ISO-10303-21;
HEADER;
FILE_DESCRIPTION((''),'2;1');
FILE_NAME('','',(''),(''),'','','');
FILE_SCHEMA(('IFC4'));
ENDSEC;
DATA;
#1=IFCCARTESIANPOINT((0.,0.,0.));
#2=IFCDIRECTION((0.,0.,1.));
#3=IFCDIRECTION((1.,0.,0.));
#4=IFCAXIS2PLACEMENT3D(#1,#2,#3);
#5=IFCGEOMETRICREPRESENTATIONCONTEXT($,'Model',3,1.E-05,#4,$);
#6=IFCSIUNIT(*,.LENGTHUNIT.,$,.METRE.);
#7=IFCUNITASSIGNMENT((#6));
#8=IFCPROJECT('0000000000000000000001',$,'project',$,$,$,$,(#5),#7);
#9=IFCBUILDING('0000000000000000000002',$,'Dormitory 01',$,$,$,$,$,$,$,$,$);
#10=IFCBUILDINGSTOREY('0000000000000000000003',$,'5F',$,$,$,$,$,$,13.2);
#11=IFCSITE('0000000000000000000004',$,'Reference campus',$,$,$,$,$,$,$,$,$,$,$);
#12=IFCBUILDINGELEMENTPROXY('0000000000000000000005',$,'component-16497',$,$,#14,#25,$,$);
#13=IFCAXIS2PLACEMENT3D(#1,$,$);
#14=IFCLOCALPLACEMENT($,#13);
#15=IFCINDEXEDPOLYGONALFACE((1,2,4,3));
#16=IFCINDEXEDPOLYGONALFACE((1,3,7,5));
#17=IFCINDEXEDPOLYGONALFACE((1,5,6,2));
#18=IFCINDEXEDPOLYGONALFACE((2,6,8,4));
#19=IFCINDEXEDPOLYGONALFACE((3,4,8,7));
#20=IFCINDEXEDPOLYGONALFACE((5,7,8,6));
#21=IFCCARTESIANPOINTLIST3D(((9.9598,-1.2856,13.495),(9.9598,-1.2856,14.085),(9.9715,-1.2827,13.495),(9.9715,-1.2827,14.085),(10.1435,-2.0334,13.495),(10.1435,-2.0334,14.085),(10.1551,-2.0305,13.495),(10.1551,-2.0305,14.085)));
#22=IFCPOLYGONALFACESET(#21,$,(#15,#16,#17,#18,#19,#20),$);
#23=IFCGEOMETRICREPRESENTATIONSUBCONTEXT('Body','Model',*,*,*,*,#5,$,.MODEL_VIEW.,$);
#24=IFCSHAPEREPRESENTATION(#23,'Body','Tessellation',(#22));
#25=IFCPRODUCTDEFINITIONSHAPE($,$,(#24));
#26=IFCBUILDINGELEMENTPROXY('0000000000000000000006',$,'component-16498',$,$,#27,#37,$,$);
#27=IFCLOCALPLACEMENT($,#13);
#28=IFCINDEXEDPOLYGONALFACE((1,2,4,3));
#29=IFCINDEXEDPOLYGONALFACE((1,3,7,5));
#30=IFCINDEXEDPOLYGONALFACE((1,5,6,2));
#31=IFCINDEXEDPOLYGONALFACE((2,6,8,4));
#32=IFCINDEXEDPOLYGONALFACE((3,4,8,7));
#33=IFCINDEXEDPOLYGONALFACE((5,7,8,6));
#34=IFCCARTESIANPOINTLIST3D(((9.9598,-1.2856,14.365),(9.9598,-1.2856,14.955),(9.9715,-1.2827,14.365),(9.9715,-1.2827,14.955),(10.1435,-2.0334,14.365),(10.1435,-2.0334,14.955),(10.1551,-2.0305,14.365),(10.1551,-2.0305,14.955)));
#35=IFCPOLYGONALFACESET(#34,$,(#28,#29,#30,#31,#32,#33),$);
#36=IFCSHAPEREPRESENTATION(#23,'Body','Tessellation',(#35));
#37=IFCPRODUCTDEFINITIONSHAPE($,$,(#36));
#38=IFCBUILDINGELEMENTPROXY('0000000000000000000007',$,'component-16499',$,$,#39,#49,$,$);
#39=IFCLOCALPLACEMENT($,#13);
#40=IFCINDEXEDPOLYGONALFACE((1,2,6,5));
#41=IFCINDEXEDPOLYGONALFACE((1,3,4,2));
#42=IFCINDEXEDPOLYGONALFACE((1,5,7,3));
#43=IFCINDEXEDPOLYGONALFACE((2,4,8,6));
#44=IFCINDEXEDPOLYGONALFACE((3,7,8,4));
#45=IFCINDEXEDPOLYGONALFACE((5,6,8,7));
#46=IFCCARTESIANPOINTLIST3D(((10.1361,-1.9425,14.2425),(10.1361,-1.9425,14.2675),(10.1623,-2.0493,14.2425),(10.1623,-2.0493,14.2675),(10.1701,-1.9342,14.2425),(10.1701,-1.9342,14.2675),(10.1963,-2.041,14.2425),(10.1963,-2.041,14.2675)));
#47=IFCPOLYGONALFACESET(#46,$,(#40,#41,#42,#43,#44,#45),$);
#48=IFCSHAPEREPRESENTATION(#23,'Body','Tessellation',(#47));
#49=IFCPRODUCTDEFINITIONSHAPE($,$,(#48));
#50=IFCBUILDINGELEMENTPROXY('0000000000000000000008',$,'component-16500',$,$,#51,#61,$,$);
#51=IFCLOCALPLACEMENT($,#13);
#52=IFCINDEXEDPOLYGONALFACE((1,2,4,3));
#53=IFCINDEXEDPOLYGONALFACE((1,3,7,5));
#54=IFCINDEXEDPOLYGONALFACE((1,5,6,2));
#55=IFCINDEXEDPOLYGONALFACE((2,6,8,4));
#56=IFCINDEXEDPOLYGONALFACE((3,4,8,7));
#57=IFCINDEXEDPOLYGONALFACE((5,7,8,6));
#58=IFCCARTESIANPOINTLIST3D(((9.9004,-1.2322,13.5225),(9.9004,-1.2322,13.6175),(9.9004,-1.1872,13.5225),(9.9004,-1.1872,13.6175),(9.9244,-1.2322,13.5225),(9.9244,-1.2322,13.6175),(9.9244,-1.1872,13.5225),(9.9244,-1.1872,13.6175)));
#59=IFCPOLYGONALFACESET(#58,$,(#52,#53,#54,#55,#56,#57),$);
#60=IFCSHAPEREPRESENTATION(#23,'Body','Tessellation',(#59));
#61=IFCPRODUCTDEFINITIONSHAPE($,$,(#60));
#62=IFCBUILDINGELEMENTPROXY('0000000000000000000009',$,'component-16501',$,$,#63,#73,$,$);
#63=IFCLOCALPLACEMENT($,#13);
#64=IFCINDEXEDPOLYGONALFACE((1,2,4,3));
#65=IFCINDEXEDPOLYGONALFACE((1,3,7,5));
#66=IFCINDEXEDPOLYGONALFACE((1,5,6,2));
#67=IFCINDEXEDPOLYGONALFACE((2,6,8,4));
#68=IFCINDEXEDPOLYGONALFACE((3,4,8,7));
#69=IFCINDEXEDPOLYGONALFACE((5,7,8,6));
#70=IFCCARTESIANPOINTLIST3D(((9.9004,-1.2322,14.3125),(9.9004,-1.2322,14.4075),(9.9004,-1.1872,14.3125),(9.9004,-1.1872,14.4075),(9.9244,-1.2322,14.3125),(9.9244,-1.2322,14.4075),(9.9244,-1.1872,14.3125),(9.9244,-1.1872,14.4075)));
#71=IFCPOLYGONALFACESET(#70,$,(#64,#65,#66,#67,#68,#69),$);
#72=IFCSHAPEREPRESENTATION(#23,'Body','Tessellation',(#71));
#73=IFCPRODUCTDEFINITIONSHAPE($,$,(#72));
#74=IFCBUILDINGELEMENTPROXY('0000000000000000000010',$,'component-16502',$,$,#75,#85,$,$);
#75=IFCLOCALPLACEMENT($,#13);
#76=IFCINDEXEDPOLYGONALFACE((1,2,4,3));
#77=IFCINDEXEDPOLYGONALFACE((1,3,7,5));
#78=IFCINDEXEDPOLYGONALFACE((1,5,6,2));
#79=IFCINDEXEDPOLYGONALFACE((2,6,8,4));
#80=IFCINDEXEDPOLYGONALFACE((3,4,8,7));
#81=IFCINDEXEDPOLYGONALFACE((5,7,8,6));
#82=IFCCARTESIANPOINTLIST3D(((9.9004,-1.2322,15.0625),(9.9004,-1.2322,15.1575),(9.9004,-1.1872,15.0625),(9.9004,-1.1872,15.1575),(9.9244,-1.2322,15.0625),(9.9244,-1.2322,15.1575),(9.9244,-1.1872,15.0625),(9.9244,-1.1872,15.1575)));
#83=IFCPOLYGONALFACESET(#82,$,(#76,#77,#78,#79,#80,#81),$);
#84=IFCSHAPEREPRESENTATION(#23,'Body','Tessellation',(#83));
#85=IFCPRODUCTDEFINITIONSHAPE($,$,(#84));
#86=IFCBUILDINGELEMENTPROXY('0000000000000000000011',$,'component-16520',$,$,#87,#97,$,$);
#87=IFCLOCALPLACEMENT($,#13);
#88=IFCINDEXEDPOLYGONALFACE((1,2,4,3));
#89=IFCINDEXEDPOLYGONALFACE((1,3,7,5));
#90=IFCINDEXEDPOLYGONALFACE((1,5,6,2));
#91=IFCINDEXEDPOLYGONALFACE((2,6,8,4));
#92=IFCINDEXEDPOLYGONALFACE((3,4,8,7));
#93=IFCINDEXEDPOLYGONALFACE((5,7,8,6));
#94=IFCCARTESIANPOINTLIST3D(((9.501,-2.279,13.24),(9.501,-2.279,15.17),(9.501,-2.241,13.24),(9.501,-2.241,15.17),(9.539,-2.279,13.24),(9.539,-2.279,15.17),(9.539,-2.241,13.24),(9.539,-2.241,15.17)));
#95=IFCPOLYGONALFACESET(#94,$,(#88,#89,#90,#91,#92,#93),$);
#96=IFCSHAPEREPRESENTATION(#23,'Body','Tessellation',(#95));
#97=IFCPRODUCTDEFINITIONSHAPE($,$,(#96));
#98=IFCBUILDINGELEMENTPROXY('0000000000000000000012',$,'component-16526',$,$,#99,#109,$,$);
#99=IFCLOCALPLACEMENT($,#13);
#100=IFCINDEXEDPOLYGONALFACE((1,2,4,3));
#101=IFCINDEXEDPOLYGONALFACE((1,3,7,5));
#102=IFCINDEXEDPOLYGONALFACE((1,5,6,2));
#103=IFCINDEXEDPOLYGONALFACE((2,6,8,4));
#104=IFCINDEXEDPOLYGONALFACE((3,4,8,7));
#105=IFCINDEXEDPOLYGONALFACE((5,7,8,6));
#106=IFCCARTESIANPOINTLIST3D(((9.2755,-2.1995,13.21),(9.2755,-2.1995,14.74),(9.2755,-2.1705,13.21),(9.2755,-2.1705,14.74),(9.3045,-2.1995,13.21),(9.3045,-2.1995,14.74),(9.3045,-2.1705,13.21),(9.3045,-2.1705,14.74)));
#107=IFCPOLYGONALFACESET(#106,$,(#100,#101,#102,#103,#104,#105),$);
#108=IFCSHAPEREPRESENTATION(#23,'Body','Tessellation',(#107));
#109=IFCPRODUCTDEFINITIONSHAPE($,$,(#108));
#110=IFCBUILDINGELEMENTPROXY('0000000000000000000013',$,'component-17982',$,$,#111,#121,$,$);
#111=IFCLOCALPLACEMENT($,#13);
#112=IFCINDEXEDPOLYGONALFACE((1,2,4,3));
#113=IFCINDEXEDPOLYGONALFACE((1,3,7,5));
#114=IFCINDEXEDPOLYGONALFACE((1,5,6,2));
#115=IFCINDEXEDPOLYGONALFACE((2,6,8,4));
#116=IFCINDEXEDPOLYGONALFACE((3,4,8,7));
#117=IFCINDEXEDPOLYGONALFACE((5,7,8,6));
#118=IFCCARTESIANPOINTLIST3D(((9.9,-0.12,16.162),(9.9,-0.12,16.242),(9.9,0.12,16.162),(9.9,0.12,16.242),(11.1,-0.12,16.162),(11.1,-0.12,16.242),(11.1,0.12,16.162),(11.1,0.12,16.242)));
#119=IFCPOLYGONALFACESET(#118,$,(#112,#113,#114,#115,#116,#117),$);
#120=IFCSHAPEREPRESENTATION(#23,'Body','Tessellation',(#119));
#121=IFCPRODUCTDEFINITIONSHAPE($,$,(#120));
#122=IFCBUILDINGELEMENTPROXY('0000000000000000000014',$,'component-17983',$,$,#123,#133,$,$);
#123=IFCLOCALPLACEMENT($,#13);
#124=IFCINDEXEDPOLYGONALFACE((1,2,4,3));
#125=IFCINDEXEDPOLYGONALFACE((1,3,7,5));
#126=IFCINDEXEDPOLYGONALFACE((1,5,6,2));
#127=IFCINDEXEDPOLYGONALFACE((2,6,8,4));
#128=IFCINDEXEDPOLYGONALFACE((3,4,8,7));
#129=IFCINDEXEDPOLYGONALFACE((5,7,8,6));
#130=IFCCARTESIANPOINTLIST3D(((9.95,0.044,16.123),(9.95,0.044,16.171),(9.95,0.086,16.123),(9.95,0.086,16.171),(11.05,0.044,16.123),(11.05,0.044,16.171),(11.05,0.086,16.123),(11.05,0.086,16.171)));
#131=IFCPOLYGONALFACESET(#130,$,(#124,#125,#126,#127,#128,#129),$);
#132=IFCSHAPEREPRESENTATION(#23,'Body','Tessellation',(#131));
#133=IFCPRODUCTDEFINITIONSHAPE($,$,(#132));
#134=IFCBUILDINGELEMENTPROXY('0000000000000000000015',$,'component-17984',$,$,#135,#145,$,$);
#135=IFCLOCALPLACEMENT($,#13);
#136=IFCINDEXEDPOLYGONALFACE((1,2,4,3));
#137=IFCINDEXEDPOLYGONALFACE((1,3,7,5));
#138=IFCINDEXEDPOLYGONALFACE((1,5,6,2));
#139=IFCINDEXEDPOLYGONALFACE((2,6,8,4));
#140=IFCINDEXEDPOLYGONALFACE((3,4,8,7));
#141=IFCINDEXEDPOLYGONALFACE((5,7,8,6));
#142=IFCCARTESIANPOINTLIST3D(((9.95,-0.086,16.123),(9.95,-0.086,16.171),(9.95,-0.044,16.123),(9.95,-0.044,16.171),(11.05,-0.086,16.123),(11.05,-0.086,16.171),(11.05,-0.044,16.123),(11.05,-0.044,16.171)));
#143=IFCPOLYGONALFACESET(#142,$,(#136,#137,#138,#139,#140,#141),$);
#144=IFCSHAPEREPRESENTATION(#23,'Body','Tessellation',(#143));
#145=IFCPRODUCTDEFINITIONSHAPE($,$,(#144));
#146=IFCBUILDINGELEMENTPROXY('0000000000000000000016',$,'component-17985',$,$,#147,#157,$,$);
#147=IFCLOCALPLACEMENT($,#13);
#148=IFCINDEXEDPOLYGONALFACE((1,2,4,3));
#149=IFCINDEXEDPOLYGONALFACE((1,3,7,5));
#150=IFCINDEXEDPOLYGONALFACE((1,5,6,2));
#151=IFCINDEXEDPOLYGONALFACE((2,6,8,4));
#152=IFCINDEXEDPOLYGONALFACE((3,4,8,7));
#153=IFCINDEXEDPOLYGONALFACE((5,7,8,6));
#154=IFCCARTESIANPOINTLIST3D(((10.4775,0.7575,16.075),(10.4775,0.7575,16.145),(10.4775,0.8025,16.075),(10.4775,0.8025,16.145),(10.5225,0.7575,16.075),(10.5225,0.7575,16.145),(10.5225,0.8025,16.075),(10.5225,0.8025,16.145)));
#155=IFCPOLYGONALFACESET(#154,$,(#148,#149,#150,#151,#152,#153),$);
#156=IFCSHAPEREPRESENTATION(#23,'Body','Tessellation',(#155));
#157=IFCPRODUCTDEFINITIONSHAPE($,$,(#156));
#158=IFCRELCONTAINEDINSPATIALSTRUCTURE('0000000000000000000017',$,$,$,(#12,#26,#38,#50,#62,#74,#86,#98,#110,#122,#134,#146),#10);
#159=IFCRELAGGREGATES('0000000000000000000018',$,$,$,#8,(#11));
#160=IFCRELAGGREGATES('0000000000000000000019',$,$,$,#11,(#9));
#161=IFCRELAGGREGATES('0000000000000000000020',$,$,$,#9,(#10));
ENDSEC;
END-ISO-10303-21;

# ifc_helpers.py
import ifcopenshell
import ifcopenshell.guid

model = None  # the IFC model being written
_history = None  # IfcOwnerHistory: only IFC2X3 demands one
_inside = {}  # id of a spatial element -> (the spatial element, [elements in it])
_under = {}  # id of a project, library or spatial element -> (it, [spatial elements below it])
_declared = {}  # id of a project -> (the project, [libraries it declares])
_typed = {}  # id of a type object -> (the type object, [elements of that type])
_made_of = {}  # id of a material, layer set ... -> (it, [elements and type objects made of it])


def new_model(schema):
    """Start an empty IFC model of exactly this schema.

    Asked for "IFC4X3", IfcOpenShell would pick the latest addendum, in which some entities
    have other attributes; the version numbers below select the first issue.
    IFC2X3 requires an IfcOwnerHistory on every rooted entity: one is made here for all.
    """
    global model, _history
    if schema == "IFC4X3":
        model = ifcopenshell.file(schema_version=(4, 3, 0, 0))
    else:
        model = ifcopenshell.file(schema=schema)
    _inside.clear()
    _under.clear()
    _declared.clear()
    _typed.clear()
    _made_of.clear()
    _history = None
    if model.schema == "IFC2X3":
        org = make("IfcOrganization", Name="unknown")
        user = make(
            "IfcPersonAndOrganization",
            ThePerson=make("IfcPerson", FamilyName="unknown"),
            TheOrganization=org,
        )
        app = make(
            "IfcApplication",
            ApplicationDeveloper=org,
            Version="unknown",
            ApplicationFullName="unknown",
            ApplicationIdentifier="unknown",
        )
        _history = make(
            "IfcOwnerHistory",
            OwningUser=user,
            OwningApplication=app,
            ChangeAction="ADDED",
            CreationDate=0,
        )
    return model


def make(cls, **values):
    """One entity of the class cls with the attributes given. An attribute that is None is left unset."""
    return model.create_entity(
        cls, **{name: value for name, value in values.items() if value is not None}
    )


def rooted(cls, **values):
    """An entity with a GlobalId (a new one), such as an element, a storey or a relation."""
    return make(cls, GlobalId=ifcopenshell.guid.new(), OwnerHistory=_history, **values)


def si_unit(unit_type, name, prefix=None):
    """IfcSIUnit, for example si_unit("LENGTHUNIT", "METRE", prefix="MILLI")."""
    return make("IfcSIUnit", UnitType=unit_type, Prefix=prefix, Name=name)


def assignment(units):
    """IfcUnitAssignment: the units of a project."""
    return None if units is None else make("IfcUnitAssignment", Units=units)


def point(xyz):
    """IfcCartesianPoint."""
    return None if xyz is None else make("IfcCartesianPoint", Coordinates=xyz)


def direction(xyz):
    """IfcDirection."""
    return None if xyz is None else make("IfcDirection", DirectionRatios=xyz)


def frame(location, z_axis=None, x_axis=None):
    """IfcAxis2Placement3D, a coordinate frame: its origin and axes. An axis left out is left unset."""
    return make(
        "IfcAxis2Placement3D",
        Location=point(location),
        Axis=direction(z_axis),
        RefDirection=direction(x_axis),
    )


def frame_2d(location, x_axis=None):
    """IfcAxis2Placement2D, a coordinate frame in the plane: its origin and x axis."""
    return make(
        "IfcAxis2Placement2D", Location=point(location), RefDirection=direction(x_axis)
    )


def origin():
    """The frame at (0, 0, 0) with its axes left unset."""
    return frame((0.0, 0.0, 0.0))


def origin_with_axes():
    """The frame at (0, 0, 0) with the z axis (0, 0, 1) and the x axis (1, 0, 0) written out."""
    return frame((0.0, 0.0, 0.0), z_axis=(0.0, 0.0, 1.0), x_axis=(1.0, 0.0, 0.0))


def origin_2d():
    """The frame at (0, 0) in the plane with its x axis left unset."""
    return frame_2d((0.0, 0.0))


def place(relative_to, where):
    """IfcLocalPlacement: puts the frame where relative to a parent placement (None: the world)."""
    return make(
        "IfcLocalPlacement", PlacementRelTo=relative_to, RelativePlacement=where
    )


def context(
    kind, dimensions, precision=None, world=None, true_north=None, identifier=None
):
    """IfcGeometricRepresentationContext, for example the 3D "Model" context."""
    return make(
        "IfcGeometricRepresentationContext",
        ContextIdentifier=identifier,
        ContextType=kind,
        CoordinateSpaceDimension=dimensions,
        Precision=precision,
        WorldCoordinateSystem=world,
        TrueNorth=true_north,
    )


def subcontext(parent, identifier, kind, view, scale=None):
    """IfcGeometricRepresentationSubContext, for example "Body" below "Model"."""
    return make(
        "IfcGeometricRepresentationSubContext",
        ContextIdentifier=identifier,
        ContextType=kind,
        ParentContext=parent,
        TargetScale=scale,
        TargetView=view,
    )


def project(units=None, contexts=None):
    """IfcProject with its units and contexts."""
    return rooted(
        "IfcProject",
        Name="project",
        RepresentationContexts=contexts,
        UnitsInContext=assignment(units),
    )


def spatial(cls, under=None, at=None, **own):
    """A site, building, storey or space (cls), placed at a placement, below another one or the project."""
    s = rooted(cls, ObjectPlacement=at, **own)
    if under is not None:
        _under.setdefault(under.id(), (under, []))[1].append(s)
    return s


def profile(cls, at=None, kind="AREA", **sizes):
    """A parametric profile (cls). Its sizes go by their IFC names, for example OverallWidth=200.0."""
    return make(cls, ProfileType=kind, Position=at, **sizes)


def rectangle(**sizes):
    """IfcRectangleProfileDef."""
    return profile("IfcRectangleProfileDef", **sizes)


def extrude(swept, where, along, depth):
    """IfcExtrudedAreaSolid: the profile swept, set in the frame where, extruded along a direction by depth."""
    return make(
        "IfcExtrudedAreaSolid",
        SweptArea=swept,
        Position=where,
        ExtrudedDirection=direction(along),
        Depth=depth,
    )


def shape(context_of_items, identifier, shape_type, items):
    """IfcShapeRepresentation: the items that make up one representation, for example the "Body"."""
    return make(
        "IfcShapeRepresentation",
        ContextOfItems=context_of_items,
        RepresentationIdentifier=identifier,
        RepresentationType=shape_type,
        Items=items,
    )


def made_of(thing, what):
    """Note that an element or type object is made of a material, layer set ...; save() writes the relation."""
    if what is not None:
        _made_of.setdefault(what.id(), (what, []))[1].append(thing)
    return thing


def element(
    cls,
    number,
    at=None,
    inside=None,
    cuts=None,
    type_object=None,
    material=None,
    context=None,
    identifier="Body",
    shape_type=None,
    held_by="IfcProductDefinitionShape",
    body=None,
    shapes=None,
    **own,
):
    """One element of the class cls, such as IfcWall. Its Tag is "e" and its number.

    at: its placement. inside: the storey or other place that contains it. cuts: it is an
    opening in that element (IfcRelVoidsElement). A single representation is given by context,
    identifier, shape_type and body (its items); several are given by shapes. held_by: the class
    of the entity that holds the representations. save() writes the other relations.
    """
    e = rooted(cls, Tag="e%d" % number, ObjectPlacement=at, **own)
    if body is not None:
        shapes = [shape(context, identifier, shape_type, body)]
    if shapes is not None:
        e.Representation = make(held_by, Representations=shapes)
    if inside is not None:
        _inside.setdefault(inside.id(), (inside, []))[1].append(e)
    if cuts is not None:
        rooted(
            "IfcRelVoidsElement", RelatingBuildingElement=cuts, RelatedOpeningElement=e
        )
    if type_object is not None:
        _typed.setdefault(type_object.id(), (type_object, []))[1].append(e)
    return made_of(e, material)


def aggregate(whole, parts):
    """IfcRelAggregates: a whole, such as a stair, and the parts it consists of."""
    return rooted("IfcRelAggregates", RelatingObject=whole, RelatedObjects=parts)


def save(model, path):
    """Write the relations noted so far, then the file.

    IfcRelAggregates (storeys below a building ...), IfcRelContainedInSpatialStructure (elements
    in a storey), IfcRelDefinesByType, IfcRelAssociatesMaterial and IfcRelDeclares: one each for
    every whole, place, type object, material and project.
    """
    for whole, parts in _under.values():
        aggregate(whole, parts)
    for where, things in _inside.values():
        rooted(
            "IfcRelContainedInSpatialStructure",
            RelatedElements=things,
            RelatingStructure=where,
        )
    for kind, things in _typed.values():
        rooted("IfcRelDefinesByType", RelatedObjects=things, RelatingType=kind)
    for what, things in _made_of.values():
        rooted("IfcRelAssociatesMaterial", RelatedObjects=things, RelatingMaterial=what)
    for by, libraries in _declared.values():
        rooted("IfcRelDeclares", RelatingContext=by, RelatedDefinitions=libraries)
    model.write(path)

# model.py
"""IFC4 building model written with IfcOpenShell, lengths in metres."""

from ifc_helpers import new_model, si_unit, frame, origin, origin_with_axes, origin_2d, place, context, subcontext, project, spatial, rectangle, extrude, element, save


model = new_model("IFC4")

# Units and contexts
model_context = context("Model", 3, precision=1e-05, world=origin_with_axes())
body_context = subcontext(model_context, "Body", "Model", "MODEL_VIEW")
ifc_project = project(units=[si_unit("LENGTHUNIT", "METRE")], contexts=[model_context])

# Site, building, storey
site = spatial("IfcSite", under=ifc_project, Name="Reference campus")
building = spatial("IfcBuilding", under=site, Name="Dormitory 01")
storey = spatial("IfcBuildingStorey", under=building, Name="5F", Elevation=13.2)

# Building element proxies
for number, where, z_axis, x_axis, name in (
    (1, (10.0575, -1.658, 13.495), (0.0, 0.0, 1.0), (0.238476, -0.971148, 0.0), "component-16497"),
    (2, (10.0575, -1.658, 14.365), (0.0, 0.0, 1.0), (0.238476, -0.971148, 0.0), "component-16498"),
):
    element("IfcBuildingElementProxy", number, at=place(None, frame(where, z_axis=z_axis, x_axis=x_axis)), inside=storey, Name=name, context=body_context, shape_type="SweptSolid", body=[
        extrude(rectangle(XDim=0.77, YDim=0.012, at=origin_2d()), origin(), (0.0, 0.0, 1.0), 0.59),
    ])
proxy_1_placement = place(None, frame((10.1662, -1.9917, 14.2425), z_axis=(0.0, 0.0, 1.0), x_axis=(0.238476, -0.971148, 0.0)))
element("IfcBuildingElementProxy", 3, at=proxy_1_placement, inside=storey, Name="component-16499", context=body_context, shape_type="SweptSolid", body=[
    extrude(rectangle(XDim=0.11, YDim=0.035, at=origin_2d()), origin(), (0.0, 0.0, 1.0), 0.025),
])
for number, where, z_axis, x_axis, name in (
    (4, (9.9124, -1.2097, 13.5225), (0.0, 0.0, 1.0), (1.0, 0.0, 0.0), "component-16500"),
    (5, (9.9124, -1.2097, 14.3125), (0.0, 0.0, 1.0), (1.0, 0.0, 0.0), "component-16501"),
    (6, (9.9124, -1.2097, 15.0625), (0.0, 0.0, 1.0), (1.0, 0.0, 0.0), "component-16502"),
):
    element("IfcBuildingElementProxy", number, at=place(None, frame(where, z_axis=z_axis, x_axis=x_axis)), inside=storey, Name=name, context=body_context, shape_type="SweptSolid", body=[
        extrude(rectangle(XDim=0.024, YDim=0.045, at=origin_2d()), origin(), (0.0, 0.0, 1.0), 0.095),
    ])
proxy_2_placement = place(None, frame((9.52, -2.26, 13.24), z_axis=(0.0, 0.0, 1.0), x_axis=(1.0, 0.0, 0.0)))
element("IfcBuildingElementProxy", 7, at=proxy_2_placement, inside=storey, Name="component-16520", context=body_context, shape_type="SweptSolid", body=[
    extrude(rectangle(XDim=0.038, YDim=0.038, at=origin_2d()), origin(), (0.0, 0.0, 1.0), 1.93),
])
proxy_3_placement = place(None, frame((9.29, -2.185, 13.21), z_axis=(0.0, 0.0, 1.0), x_axis=(1.0, 0.0, 0.0)))
element("IfcBuildingElementProxy", 8, at=proxy_3_placement, inside=storey, Name="component-16526", context=body_context, shape_type="SweptSolid", body=[
    extrude(rectangle(XDim=0.029, YDim=0.029, at=origin_2d()), origin(), (0.0, 0.0, 1.0), 1.53),
])
proxy_4_placement = place(None, frame((10.5, 0.0, 16.162), z_axis=(0.0, 0.0, 1.0), x_axis=(1.0, 0.0, 0.0)))
element("IfcBuildingElementProxy", 9, at=proxy_4_placement, inside=storey, Name="component-17982", context=body_context, shape_type="SweptSolid", body=[
    extrude(rectangle(XDim=1.2, YDim=0.24, at=origin_2d()), origin(), (0.0, 0.0, 1.0), 0.08),
])
for number, where, z_axis, x_axis, name in (
    (10, (10.5, 0.065, 16.123), (0.0, 0.0, 1.0), (1.0, 0.0, 0.0), "component-17983"),
    (11, (10.5, -0.065, 16.123), (0.0, 0.0, 1.0), (1.0, 0.0, 0.0), "component-17984"),
):
    element("IfcBuildingElementProxy", number, at=place(None, frame(where, z_axis=z_axis, x_axis=x_axis)), inside=storey, Name=name, context=body_context, shape_type="SweptSolid", body=[
        extrude(rectangle(XDim=1.1, YDim=0.042, at=origin_2d()), origin(), (0.0, 0.0, 1.0), 0.048),
    ])
proxy_5_placement = place(None, frame((10.5, 0.78, 16.075), z_axis=(0.0, 0.0, 1.0), x_axis=(1.0, 0.0, 0.0)))
element("IfcBuildingElementProxy", 12, at=proxy_5_placement, inside=storey, Name="component-17985", context=body_context, shape_type="SweptSolid", body=[
    extrude(rectangle(XDim=0.045, YDim=0.045, at=origin_2d()), origin(), (0.0, 0.0, 1.0), 0.07),
])

save(model, "model.ifc")
